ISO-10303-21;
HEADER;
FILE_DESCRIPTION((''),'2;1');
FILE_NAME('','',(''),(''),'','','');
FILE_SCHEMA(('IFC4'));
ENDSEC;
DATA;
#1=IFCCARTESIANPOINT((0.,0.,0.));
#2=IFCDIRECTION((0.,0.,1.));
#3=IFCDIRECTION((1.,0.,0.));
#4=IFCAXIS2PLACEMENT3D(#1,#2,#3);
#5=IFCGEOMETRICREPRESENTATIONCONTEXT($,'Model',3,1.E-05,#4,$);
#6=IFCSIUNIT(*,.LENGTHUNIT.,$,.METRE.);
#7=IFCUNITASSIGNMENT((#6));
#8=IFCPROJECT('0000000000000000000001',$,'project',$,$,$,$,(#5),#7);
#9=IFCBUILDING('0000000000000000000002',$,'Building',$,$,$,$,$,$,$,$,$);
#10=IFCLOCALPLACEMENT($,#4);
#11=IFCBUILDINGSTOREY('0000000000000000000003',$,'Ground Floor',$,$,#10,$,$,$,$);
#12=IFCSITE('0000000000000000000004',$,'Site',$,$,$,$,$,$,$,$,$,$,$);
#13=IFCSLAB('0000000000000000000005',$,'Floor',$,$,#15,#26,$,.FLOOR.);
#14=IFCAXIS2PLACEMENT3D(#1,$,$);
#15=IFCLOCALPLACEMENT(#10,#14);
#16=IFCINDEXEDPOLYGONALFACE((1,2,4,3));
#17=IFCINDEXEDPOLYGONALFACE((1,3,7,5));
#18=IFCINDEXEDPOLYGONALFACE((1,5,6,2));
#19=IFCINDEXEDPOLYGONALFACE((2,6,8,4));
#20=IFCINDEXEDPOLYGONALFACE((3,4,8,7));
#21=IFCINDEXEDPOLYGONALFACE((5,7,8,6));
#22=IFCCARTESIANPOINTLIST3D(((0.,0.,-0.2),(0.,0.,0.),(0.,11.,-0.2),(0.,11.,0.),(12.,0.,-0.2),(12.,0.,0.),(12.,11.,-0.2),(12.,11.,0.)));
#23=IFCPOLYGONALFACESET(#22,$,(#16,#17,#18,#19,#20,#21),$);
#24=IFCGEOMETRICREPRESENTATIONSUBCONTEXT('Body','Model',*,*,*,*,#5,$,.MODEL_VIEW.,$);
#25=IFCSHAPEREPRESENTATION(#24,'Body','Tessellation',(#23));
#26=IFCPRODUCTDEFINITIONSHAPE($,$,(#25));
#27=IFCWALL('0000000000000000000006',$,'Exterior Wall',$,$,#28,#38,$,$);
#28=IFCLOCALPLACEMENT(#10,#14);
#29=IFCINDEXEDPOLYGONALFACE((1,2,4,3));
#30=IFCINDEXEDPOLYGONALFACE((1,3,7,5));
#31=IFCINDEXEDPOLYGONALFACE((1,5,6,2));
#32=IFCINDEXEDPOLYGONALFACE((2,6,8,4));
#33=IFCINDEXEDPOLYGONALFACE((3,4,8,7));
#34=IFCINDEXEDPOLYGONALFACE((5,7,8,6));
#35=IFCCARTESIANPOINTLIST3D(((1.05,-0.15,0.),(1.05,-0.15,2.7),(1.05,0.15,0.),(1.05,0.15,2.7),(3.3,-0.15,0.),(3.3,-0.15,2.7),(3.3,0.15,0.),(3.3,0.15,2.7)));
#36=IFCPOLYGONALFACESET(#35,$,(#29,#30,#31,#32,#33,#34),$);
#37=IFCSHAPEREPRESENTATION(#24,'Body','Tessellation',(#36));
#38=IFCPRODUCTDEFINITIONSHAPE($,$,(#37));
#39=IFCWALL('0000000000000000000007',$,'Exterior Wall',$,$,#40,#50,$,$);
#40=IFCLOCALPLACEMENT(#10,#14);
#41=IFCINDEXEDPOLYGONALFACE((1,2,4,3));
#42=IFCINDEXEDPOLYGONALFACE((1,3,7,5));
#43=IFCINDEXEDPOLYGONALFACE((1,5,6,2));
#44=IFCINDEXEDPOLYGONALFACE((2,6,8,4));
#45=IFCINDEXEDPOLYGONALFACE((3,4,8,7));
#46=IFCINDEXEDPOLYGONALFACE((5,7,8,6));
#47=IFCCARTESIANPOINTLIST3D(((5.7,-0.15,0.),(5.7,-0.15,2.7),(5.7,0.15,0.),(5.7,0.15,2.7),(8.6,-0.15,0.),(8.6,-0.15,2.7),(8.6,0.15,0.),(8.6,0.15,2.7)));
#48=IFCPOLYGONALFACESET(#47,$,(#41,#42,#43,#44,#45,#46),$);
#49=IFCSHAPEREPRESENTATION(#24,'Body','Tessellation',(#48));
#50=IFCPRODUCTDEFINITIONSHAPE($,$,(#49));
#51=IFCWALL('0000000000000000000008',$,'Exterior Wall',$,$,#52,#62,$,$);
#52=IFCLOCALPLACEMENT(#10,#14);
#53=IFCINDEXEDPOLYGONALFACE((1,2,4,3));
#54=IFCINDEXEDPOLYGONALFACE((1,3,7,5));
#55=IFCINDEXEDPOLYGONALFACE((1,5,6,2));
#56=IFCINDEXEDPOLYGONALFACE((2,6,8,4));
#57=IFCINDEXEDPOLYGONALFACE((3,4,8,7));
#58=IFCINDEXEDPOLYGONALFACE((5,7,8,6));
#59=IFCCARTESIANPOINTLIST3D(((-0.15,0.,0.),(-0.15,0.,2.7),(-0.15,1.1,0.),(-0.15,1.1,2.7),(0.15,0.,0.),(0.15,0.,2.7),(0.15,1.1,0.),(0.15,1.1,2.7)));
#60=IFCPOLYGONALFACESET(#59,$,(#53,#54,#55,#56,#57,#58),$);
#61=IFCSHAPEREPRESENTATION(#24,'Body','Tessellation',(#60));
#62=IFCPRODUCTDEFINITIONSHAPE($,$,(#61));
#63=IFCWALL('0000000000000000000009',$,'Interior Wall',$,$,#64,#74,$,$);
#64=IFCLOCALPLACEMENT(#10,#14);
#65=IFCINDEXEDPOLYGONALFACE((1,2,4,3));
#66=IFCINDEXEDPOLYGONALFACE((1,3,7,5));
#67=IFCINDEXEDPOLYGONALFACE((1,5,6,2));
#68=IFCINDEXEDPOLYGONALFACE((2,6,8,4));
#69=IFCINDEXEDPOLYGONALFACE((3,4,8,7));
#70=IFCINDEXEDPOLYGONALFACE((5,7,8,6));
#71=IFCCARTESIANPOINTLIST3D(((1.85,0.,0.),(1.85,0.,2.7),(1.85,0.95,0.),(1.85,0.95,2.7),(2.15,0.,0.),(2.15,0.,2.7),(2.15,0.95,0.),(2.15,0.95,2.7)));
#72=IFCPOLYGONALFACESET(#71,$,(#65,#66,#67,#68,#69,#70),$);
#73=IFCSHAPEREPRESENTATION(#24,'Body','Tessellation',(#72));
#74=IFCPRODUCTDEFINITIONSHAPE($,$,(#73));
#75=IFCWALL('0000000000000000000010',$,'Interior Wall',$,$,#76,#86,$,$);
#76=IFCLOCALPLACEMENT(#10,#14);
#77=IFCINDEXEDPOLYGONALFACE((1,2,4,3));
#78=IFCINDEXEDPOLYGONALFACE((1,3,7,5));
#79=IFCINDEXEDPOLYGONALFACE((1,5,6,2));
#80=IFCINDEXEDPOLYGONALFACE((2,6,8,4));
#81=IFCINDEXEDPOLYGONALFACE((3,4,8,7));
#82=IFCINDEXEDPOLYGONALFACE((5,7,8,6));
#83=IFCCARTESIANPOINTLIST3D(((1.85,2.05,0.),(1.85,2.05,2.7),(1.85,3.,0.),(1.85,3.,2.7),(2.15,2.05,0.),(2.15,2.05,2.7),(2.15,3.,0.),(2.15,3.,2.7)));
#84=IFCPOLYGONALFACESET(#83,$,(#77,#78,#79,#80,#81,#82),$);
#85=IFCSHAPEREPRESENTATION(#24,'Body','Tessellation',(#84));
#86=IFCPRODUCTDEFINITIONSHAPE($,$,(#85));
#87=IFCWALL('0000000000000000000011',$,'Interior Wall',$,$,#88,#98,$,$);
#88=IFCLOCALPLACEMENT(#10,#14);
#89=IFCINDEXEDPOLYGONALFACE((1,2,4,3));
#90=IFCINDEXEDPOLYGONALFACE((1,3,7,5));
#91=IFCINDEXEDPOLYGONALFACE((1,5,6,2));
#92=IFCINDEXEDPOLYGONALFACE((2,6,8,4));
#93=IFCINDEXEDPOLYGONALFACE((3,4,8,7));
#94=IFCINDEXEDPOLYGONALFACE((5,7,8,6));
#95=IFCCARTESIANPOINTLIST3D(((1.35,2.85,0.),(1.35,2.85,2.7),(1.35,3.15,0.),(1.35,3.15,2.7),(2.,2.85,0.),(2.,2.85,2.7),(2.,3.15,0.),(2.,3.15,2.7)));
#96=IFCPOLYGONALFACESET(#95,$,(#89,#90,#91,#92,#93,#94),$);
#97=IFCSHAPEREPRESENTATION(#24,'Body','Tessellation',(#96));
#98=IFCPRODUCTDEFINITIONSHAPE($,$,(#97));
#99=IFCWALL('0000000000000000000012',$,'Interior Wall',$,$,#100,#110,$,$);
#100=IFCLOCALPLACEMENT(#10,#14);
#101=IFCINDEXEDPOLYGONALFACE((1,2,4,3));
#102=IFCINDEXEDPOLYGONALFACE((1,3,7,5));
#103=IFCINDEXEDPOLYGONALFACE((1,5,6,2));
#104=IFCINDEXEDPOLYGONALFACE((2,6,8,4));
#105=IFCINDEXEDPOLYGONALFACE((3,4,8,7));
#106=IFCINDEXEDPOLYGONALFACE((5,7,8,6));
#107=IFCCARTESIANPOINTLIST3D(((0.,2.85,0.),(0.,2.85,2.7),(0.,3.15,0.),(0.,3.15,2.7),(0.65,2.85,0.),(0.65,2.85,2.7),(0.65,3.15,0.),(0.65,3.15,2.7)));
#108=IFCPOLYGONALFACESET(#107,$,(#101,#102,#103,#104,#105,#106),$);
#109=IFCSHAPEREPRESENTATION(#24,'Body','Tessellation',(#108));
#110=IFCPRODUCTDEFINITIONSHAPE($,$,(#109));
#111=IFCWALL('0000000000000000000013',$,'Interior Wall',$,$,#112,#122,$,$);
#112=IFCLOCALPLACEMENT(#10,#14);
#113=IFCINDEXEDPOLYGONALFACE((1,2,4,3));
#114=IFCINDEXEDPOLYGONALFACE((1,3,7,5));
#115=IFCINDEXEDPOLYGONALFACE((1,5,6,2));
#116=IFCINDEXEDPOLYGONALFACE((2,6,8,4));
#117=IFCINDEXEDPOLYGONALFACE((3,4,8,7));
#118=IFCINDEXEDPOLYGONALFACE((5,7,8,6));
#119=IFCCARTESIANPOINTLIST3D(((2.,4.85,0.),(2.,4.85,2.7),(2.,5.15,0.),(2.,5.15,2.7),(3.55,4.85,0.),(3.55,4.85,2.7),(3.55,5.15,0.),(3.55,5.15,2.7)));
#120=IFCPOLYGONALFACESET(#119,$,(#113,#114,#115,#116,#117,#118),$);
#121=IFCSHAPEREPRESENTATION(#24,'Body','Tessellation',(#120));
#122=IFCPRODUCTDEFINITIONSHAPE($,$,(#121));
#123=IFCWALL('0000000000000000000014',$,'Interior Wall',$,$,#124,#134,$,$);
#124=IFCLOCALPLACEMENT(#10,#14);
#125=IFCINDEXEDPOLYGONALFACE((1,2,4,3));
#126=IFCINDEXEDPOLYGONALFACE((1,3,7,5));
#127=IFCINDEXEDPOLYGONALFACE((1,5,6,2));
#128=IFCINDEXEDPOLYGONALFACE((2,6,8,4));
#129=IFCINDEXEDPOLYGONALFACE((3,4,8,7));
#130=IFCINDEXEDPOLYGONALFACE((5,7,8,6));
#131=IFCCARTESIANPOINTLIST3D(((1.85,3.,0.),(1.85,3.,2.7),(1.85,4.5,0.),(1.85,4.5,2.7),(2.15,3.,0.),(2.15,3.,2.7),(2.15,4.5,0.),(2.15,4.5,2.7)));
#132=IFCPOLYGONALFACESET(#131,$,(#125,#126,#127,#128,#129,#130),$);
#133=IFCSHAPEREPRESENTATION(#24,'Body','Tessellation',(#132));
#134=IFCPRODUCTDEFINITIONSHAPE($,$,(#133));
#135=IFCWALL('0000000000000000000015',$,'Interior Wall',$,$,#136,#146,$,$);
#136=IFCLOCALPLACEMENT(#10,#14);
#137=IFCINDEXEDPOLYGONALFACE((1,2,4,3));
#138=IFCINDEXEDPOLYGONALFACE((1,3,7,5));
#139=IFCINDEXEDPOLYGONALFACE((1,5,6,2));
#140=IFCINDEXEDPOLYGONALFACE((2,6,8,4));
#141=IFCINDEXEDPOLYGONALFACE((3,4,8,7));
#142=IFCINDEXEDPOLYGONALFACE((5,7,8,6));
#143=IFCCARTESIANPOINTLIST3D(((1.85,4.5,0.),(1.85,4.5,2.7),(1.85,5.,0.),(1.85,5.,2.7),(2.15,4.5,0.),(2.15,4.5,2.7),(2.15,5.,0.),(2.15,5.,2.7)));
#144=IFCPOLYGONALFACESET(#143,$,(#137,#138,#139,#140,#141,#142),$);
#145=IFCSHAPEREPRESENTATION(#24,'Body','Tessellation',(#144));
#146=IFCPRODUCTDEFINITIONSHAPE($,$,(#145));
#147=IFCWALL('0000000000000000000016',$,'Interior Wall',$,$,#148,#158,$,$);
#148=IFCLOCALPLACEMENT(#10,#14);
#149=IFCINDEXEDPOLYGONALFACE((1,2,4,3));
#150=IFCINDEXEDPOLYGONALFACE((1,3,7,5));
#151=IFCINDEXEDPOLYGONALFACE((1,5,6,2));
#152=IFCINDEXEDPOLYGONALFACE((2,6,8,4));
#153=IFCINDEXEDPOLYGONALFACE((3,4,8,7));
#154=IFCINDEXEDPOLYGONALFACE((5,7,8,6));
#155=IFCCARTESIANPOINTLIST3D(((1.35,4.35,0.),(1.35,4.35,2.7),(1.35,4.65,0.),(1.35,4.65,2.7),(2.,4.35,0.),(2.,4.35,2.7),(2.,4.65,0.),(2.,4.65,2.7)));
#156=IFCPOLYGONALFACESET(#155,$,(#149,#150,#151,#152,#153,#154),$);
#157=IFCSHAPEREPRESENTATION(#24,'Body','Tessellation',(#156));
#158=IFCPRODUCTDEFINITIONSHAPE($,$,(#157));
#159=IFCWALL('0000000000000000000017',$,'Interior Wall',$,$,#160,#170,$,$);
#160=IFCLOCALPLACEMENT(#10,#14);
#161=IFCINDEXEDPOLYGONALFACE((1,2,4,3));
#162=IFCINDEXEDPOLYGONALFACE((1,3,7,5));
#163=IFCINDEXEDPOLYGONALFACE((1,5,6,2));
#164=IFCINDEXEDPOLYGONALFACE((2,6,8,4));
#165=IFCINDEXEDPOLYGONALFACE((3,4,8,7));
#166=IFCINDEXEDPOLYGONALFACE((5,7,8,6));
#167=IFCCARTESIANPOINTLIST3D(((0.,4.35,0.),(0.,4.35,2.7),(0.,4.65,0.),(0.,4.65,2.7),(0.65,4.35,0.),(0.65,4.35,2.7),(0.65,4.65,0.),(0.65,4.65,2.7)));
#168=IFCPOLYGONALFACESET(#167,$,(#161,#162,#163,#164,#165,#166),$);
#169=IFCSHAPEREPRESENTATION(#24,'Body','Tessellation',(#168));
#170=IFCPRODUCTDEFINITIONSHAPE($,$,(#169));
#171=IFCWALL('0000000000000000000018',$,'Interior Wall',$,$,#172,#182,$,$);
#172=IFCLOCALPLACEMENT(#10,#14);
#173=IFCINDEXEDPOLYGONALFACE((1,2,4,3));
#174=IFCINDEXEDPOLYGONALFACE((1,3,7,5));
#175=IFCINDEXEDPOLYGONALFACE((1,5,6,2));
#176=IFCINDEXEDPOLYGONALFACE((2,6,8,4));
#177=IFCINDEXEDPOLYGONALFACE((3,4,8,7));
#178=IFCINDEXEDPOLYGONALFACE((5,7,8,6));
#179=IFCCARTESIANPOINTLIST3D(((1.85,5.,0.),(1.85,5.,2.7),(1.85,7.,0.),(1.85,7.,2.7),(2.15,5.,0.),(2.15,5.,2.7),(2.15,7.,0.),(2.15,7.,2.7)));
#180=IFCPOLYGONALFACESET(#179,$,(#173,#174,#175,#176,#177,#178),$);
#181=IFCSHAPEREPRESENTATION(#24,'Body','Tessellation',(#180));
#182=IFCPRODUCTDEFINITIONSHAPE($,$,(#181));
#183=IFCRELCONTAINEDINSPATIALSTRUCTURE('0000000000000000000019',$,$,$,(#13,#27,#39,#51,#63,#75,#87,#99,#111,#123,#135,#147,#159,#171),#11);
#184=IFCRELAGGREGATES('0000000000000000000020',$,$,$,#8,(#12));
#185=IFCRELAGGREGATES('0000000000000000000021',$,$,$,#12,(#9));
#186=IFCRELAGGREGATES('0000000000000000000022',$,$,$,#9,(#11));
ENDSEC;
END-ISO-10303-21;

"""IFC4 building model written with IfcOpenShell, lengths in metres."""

from ifc_helpers import new_model, si_unit, frame, origin_with_axes, place, context, subcontext, project, spatial, indexed_curve, outline, extrude, element, save


model = new_model("IFC4")

# Units and contexts
model_context = context("Model", 3, precision=1e-05, world=origin_with_axes())
body_context = subcontext(model_context, "Body", "Model", "MODEL_VIEW")
ifc_project = project(units=[si_unit("LENGTHUNIT", "METRE")], contexts=[model_context])

# Site, building, storey
site = spatial("IfcSite", under=ifc_project, Name="Site")
building = spatial("IfcBuilding", under=site, Name="Building")
storey_placement = place(None, origin_with_axes())
storey = spatial("IfcBuildingStorey", under=building, at=storey_placement, Name="Ground Floor")

# Slab
slab_placement = place(storey_placement, frame((0.0, 0.0, -0.2), z_axis=(0.0, 0.0, 1.0), x_axis=(1.0, 0.0, 0.0)))
element("IfcSlab", 1, at=slab_placement, inside=storey, Name="Floor", PredefinedType="FLOOR", context=body_context, shape_type="SweptSolid", body=[
    extrude(outline(indexed_curve([(0.0, 0.0), (12.0, 0.0), (12.0, 11.0), (0.0, 11.0)])), None, (0.0, 0.0, 1.0), 0.2),
])

# Walls
wall_1_placement = place(storey_placement, frame((1.05, 0.0, 0.0), z_axis=(0.0, 0.0, 1.0), x_axis=(1.0, 0.0, 0.0)))
element("IfcWall", 2, at=wall_1_placement, inside=storey, Name="Exterior Wall", context=body_context, shape_type="SweptSolid", body=[
    extrude(outline(indexed_curve([(0.0, 0.0), (0.0, 0.3), (2.25, 0.3), (2.25, 0.0), (0.0, 0.0)], self_intersect=False)), frame((0.0, -0.15, 0.0), z_axis=(0.0, 0.0, 1.0), x_axis=(1.0, 0.0, 0.0)), (0.0, 0.0, 1.0), 2.7),
])
wall_2_placement = place(storey_placement, frame((5.7, 0.0, 0.0), z_axis=(0.0, 0.0, 1.0), x_axis=(1.0, 0.0, 0.0)))
element("IfcWall", 3, at=wall_2_placement, inside=storey, Name="Exterior Wall", context=body_context, shape_type="SweptSolid", body=[
    extrude(outline(indexed_curve([(0.0, 0.0), (0.0, 0.3), (2.9, 0.3), (2.9, 0.0), (0.0, 0.0)], self_intersect=False)), frame((0.0, -0.15, 0.0), z_axis=(0.0, 0.0, 1.0), x_axis=(1.0, 0.0, 0.0)), (0.0, 0.0, 1.0), 2.7),
])
wall_3_placement = place(storey_placement, frame((0.0, 1.1, 0.0), z_axis=(0.0, 0.0, 1.0), x_axis=(0.0, -1.0, 0.0)))
element("IfcWall", 4, at=wall_3_placement, inside=storey, Name="Exterior Wall", context=body_context, shape_type="SweptSolid", body=[
    extrude(outline(indexed_curve([(0.0, 0.0), (0.0, 0.3), (1.1, 0.3), (1.1, 0.0), (0.0, 0.0)], self_intersect=False)), frame((0.0, -0.15, 0.0), z_axis=(0.0, 0.0, 1.0), x_axis=(1.0, 0.0, 0.0)), (0.0, 0.0, 1.0), 2.7),
])
wall_4_placement = place(storey_placement, frame((2.0, 0.0, 0.0), z_axis=(0.0, 0.0, 1.0), x_axis=(0.0, 1.0, 0.0)))
element("IfcWall", 5, at=wall_4_placement, inside=storey, Name="Interior Wall", context=body_context, shape_type="SweptSolid", body=[
    extrude(outline(indexed_curve([(0.0, 0.0), (0.0, 0.3), (0.95, 0.3), (0.95, 0.0), (0.0, 0.0)], self_intersect=False)), frame((0.0, -0.15, 0.0), z_axis=(0.0, 0.0, 1.0), x_axis=(1.0, 0.0, 0.0)), (0.0, 0.0, 1.0), 2.7),
])
wall_5_placement = place(storey_placement, frame((2.0, 2.05, 0.0), z_axis=(0.0, 0.0, 1.0), x_axis=(0.0, 1.0, 0.0)))
element("IfcWall", 6, at=wall_5_placement, inside=storey, Name="Interior Wall", context=body_context, shape_type="SweptSolid", body=[
    extrude(outline(indexed_curve([(0.0, 0.0), (0.0, 0.3), (0.95, 0.3), (0.95, 0.0), (0.0, 0.0)], self_intersect=False)), frame((0.0, -0.15, 0.0), z_axis=(0.0, 0.0, 1.0), x_axis=(1.0, 0.0, 0.0)), (0.0, 0.0, 1.0), 2.7),
])
for number, where, z_axis, x_axis, name in (
    (7, (2.0, 3.0, 0.0), (0.0, 0.0, 1.0), (-1.0, 0.0, 0.0), "Interior Wall"),
    (8, (0.65, 3.0, 0.0), (0.0, 0.0, 1.0), (-1.0, 0.0, 0.0), "Interior Wall"),
):
    element("IfcWall", number, at=place(storey_placement, frame(where, z_axis=z_axis, x_axis=x_axis)), inside=storey, Name=name, context=body_context, shape_type="SweptSolid", body=[
        extrude(outline(indexed_curve([(0.0, 0.0), (0.0, 0.3), (0.65, 0.3), (0.65, 0.0), (0.0, 0.0)], self_intersect=False)), frame((0.0, -0.15, 0.0), z_axis=(0.0, 0.0, 1.0), x_axis=(1.0, 0.0, 0.0)), (0.0, 0.0, 1.0), 2.7),
    ])
wall_6_placement = place(storey_placement, frame((3.55, 5.0, 0.0), z_axis=(0.0, 0.0, 1.0), x_axis=(-1.0, 0.0, 0.0)))
element("IfcWall", 9, at=wall_6_placement, inside=storey, Name="Interior Wall", context=body_context, shape_type="SweptSolid", body=[
    extrude(outline(indexed_curve([(0.0, 0.0), (0.0, 0.3), (1.55, 0.3), (1.55, 0.0), (0.0, 0.0)], self_intersect=False)), frame((0.0, -0.15, 0.0), z_axis=(0.0, 0.0, 1.0), x_axis=(1.0, 0.0, 0.0)), (0.0, 0.0, 1.0), 2.7),
])
wall_7_placement = place(storey_placement, frame((2.0, 4.5, 0.0), z_axis=(0.0, 0.0, 1.0), x_axis=(0.0, -1.0, 0.0)))
element("IfcWall", 10, at=wall_7_placement, inside=storey, Name="Interior Wall", context=body_context, shape_type="SweptSolid", body=[
    extrude(outline(indexed_curve([(0.0, 0.0), (0.0, 0.3), (1.5, 0.3), (1.5, 0.0), (0.0, 0.0)], self_intersect=False)), frame((0.0, -0.15, 0.0), z_axis=(0.0, 0.0, 1.0), x_axis=(1.0, 0.0, 0.0)), (0.0, 0.0, 1.0), 2.7),
])
wall_8_placement = place(storey_placement, frame((2.0, 5.0, 0.0), z_axis=(0.0, 0.0, 1.0), x_axis=(0.0, -1.0, 0.0)))
element("IfcWall", 11, at=wall_8_placement, inside=storey, Name="Interior Wall", context=body_context, shape_type="SweptSolid", body=[
    extrude(outline(indexed_curve([(0.0, 0.0), (0.0, 0.3), (0.5, 0.3), (0.5, 0.0), (0.0, 0.0)], self_intersect=False)), frame((0.0, -0.15, 0.0), z_axis=(0.0, 0.0, 1.0), x_axis=(1.0, 0.0, 0.0)), (0.0, 0.0, 1.0), 2.7),
])
for number, where, z_axis, x_axis, name in (
    (12, (2.0, 4.5, 0.0), (0.0, 0.0, 1.0), (-1.0, 0.0, 0.0), "Interior Wall"),
    (13, (0.65, 4.5, 0.0), (0.0, 0.0, 1.0), (-1.0, 0.0, 0.0), "Interior Wall"),
):
    element("IfcWall", number, at=place(storey_placement, frame(where, z_axis=z_axis, x_axis=x_axis)), inside=storey, Name=name, context=body_context, shape_type="SweptSolid", body=[
        extrude(outline(indexed_curve([(0.0, 0.0), (0.0, 0.3), (0.65, 0.3), (0.65, 0.0), (0.0, 0.0)], self_intersect=False)), frame((0.0, -0.15, 0.0), z_axis=(0.0, 0.0, 1.0), x_axis=(1.0, 0.0, 0.0)), (0.0, 0.0, 1.0), 2.7),
    ])
wall_9_placement = place(storey_placement, frame((2.0, 5.0, 0.0), z_axis=(0.0, 0.0, 1.0), x_axis=(0.0, 1.0, 0.0)))
element("IfcWall", 14, at=wall_9_placement, inside=storey, Name="Interior Wall", context=body_context, shape_type="SweptSolid", body=[
    extrude(outline(indexed_curve([(0.0, 0.0), (0.0, 0.3), (2.0, 0.3), (2.0, 0.0), (0.0, 0.0)], self_intersect=False)), frame((0.0, -0.15, 0.0), z_axis=(0.0, 0.0, 1.0), x_axis=(1.0, 0.0, 0.0)), (0.0, 0.0, 1.0), 2.7),
])

save(model, "model.ifc")
